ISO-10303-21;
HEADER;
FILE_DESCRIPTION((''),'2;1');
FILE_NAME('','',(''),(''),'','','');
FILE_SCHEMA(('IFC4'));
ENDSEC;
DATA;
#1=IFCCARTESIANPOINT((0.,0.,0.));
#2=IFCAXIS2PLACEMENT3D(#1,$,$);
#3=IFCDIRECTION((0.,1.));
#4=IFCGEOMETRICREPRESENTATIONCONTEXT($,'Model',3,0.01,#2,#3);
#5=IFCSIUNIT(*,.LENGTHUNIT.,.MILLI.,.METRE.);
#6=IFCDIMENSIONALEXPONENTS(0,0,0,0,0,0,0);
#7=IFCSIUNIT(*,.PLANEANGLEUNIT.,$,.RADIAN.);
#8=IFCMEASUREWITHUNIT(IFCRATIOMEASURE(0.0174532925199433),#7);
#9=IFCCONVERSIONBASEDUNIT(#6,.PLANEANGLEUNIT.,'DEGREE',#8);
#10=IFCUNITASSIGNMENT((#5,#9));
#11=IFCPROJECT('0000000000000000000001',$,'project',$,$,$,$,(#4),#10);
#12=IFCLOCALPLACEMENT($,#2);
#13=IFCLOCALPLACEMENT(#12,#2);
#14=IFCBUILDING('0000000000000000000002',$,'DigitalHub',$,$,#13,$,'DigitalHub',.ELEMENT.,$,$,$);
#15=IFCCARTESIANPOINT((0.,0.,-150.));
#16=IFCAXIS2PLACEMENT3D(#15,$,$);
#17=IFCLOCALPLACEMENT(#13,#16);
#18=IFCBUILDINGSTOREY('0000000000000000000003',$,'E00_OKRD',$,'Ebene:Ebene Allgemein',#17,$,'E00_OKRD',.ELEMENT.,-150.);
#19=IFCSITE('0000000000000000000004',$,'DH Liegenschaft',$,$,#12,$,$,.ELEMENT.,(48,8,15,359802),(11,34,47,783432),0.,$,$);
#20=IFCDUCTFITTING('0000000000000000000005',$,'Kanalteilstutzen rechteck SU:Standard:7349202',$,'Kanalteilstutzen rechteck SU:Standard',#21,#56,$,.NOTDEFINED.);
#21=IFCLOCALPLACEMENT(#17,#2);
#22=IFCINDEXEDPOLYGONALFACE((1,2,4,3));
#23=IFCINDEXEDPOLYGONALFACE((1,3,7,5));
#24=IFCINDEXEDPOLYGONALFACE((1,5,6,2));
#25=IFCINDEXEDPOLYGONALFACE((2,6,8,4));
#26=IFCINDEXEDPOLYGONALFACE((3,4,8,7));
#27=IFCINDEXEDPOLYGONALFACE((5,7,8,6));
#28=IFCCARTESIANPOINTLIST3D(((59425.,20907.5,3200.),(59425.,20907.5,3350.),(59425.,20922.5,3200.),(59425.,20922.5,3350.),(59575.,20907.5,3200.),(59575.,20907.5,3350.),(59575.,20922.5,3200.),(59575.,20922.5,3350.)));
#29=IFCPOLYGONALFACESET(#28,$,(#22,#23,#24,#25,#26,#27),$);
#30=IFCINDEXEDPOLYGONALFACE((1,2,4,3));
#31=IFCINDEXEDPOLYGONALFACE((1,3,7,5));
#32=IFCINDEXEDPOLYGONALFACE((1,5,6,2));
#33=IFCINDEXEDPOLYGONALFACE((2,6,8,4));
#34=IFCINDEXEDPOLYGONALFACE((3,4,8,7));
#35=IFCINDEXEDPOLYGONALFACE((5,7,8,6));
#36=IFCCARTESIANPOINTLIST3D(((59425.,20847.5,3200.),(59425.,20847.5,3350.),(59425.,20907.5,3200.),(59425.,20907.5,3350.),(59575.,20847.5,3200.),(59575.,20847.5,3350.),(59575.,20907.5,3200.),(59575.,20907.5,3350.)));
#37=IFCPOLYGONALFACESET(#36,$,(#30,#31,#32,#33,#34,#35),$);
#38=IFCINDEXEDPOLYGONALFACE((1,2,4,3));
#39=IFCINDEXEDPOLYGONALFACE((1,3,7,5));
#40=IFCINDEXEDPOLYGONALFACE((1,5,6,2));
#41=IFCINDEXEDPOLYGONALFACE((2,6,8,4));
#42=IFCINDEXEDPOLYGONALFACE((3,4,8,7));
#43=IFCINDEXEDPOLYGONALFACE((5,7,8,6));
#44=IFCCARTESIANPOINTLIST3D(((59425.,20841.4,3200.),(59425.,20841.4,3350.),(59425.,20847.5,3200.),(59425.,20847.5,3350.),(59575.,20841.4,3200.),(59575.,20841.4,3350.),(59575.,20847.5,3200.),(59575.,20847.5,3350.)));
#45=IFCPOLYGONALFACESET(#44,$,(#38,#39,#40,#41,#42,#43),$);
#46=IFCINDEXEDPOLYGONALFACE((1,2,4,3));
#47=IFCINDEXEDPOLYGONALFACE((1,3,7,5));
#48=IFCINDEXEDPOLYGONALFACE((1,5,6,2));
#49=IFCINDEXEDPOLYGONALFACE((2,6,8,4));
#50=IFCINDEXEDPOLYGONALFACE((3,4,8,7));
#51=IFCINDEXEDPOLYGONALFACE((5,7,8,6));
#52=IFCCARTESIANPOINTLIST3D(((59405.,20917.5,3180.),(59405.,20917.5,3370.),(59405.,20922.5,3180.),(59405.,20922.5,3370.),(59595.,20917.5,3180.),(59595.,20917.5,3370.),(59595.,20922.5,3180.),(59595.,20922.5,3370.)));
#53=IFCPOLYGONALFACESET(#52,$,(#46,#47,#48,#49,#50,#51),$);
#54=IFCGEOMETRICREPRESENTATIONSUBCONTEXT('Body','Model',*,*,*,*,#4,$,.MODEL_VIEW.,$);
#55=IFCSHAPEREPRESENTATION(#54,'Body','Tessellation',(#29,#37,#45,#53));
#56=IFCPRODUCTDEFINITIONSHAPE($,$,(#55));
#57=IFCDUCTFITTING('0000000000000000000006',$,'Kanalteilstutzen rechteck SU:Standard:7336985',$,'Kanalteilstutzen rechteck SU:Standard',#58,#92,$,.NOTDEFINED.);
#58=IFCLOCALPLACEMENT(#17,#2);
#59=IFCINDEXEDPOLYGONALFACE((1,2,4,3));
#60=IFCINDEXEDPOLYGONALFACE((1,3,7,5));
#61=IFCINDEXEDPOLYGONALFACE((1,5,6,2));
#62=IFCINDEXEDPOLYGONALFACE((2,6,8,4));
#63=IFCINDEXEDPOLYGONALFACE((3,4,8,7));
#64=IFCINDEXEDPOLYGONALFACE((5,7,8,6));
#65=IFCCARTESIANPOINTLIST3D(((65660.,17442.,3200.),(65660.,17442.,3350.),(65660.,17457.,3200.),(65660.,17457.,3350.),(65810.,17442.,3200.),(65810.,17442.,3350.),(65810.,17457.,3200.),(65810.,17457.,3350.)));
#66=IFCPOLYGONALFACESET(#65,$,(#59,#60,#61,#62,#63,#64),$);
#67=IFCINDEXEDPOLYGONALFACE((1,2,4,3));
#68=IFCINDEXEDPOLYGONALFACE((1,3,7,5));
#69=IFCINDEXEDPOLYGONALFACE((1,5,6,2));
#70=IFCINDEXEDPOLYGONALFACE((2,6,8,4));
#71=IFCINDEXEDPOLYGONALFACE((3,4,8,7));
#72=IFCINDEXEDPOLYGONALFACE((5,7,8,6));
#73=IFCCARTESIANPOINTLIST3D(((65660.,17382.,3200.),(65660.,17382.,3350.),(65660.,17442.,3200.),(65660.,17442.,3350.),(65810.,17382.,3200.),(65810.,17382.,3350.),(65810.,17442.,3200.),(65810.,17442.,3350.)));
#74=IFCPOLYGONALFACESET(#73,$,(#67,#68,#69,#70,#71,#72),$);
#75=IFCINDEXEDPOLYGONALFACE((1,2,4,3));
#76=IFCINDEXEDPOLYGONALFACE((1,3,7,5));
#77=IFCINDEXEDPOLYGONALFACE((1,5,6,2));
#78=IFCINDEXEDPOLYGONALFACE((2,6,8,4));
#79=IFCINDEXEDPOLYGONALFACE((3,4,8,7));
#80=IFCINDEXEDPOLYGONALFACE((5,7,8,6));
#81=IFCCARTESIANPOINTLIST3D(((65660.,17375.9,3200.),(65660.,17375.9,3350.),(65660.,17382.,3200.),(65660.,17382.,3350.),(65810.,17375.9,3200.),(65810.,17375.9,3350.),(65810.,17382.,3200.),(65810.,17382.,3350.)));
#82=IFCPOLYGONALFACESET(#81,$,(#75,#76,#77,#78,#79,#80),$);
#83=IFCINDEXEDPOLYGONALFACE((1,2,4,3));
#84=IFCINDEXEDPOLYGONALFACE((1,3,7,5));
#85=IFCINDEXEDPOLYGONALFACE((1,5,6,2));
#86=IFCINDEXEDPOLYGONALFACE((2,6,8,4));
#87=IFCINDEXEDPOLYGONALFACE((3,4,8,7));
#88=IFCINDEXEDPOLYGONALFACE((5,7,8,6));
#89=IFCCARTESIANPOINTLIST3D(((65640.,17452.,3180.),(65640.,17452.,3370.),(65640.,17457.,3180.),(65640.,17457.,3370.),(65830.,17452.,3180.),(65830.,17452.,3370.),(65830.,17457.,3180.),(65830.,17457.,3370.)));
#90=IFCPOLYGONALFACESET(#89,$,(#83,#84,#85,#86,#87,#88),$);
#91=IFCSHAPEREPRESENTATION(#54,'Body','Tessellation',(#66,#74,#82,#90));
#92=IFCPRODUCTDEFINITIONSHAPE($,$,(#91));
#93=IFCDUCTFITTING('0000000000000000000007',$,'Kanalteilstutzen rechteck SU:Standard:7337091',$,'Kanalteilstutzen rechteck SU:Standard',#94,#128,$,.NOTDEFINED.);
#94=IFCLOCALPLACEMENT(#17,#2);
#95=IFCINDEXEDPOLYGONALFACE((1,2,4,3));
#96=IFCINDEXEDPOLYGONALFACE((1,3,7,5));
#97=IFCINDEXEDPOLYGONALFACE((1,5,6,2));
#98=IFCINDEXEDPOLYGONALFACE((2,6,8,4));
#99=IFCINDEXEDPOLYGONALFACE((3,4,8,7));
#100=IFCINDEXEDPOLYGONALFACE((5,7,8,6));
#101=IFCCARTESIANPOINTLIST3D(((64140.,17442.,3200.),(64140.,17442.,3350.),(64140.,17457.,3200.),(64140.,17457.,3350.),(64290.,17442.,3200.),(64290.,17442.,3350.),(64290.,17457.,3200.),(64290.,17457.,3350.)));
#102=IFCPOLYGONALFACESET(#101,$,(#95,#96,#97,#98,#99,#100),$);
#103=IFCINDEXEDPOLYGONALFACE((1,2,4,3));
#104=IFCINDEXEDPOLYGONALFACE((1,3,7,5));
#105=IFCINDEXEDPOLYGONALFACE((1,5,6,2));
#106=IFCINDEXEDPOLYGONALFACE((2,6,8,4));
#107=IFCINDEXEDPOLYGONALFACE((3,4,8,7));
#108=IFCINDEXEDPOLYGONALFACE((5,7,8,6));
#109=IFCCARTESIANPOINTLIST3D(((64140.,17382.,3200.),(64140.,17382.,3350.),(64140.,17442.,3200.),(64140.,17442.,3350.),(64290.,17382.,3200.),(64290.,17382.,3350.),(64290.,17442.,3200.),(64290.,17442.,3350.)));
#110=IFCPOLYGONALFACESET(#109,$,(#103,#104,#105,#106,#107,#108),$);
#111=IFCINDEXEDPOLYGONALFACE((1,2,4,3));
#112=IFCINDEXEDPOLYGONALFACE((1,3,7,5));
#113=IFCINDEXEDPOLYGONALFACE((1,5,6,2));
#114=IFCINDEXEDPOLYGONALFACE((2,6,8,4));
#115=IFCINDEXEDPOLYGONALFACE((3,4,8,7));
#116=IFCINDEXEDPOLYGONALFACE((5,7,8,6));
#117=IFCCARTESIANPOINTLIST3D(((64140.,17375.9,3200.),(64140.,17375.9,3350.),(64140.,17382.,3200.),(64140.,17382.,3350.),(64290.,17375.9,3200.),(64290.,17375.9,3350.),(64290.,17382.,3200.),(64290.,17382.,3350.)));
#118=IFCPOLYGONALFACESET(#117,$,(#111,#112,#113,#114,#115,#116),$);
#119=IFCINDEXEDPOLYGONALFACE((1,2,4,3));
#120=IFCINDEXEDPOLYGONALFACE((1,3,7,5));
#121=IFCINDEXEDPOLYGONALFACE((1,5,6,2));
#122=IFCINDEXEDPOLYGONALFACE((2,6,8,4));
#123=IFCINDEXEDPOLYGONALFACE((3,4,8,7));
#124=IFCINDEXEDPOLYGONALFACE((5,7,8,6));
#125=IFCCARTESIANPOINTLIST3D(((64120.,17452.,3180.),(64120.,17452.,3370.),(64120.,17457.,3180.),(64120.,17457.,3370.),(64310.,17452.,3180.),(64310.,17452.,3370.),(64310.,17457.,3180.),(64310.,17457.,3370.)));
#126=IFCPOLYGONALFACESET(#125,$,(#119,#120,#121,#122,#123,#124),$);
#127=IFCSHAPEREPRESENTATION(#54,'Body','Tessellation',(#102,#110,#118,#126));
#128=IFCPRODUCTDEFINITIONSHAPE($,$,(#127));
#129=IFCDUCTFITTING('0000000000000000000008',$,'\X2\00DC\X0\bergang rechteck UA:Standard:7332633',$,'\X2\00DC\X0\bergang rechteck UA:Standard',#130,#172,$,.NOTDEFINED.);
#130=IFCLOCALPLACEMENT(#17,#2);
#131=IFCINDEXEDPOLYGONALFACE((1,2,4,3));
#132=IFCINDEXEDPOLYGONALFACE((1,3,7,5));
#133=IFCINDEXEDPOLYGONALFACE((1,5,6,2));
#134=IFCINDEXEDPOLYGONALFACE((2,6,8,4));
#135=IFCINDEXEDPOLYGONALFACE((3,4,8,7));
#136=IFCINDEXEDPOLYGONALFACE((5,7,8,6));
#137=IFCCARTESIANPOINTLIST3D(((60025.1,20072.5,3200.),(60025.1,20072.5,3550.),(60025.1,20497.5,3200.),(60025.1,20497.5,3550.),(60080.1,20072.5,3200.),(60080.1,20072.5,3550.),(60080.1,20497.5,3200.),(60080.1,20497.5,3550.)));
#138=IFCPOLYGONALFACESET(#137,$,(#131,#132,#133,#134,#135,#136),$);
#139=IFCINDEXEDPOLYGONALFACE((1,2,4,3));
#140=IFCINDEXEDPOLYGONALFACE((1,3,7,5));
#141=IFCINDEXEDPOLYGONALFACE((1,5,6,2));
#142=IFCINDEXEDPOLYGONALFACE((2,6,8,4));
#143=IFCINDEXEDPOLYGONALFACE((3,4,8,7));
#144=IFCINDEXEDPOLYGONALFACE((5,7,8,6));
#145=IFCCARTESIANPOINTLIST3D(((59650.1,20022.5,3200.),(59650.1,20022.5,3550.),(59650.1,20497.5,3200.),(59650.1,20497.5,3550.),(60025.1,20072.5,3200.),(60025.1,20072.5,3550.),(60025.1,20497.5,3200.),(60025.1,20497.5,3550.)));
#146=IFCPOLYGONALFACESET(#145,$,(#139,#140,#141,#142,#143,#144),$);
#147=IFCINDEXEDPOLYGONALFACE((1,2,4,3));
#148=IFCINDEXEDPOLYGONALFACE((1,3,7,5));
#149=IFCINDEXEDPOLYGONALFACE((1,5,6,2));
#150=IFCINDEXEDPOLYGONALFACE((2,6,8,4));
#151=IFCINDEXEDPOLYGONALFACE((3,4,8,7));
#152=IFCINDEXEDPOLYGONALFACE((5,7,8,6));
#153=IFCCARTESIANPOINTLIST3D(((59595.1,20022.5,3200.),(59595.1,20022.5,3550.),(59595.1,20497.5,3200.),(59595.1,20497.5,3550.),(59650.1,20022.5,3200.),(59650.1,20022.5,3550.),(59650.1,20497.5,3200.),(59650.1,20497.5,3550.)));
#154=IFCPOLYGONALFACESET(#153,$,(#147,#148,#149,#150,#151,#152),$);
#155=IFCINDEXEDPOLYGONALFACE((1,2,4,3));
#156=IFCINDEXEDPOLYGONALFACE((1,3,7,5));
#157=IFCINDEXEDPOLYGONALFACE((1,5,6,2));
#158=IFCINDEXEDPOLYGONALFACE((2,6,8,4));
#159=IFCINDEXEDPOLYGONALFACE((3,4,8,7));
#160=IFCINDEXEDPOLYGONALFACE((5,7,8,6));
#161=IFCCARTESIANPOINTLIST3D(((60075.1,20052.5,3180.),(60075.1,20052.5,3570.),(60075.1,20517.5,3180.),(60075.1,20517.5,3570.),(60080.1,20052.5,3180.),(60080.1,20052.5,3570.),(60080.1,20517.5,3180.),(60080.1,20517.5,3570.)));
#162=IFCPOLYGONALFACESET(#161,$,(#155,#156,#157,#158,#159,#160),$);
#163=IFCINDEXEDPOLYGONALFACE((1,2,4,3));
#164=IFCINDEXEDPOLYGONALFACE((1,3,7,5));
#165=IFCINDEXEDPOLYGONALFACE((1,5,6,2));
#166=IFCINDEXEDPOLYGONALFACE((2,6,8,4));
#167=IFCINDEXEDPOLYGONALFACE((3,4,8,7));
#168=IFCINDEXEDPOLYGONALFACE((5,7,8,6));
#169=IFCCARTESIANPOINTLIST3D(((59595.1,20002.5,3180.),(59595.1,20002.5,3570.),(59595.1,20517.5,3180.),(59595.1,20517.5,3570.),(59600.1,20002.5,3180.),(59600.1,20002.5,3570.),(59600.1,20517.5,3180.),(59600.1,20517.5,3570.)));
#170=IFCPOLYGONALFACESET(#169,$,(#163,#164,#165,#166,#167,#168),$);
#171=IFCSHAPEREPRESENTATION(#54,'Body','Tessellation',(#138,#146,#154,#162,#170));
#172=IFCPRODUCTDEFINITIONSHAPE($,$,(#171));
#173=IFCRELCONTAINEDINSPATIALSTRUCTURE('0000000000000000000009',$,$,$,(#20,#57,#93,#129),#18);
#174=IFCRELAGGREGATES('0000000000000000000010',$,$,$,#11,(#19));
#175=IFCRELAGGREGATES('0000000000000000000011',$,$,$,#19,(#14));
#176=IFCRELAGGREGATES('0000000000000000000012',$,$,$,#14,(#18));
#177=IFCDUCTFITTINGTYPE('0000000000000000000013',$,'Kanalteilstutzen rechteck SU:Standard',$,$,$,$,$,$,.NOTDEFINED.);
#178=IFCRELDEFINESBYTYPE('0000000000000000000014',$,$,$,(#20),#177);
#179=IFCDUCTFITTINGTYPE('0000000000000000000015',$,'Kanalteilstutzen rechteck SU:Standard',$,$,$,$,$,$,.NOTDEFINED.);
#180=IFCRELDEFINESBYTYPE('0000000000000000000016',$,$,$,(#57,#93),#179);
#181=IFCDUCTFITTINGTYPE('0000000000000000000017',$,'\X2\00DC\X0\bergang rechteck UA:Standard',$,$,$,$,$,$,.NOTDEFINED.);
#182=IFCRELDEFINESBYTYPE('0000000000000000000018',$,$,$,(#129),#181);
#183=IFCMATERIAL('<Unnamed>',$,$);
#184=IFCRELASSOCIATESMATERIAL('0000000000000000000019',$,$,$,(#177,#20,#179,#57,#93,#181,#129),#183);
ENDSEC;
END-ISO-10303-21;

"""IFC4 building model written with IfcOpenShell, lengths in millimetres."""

from ifc_helpers import new_model, entity, si_unit, converted_unit, direction, frame, origin, place, context, subcontext, project, spatial, indexed_curve, outline, extrude, source, transform, mapped, material, type_object, type_shapes, element, save


model = new_model("IFC4")

# Units and contexts
model_context = context("Model", 3, precision=0.01, world=origin(), true_north=direction((0.0, 1.0)))
body_context = subcontext(model_context, "Body", "Model", "MODEL_VIEW")
ifc_project = project(units=[si_unit("LENGTHUNIT", "METRE", prefix="MILLI"), converted_unit("PLANEANGLEUNIT", "DEGREE", entity("IfcRatioMeasure", 0.0174532925199433), si_unit("PLANEANGLEUNIT", "RADIAN"), dimensions=[0, 0, 0, 0, 0, 0, 0])], contexts=[model_context])

# Site, building, storey
site_placement = place(None, origin())
site = spatial("IfcSite", under=ifc_project, at=site_placement, Name="DH Liegenschaft", CompositionType="ELEMENT", RefLatitude=(48, 8, 15, 359802), RefLongitude=(11, 34, 47, 783432), RefElevation=0.0)
building_placement = place(site_placement, origin())
building = spatial("IfcBuilding", under=site, at=building_placement, Name="DigitalHub", LongName="DigitalHub", CompositionType="ELEMENT")
storey_placement = place(building_placement, frame((0.0, 0.0, -150.0)))
storey = spatial("IfcBuildingStorey", under=building, at=storey_placement, Name="E00_OKRD", ObjectType="Ebene:Ebene Allgemein", LongName="E00_OKRD", CompositionType="ELEMENT", Elevation=-150.0)

# Shared definitions
ifc_material_1 = material(Name="<Unnamed>")

# Duct fittings
duct_fitting_type_1 = type_object("IfcDuctFittingType", Name="Kanalteilstutzen rechteck SU:Standard", PredefinedType="NOTDEFINED", material=ifc_material_1)
shared_shape_1 = source(origin(), body_context, "Body", "SweptSolid", [
    extrude(outline(indexed_curve([(-75.0, -7.5), (75.0, -7.5), (75.0, 7.5), (-75.0, 7.5), (-75.0, -7.5)], self_intersect=False)), frame((67.5, 0.0, -75.0), z_axis=(0.0, 0.0, 1.0), x_axis=(0.0, -1.0, 0.0)), (0.0, 0.0, 1.0), 150.0),
    extrude(outline(indexed_curve([(-75.0, -30.0), (75.0, -30.0), (75.0, 30.0), (-75.0, 30.0), (-75.0, -30.0)], self_intersect=False)), frame((30.0, 0.0, -75.0), z_axis=(0.0, 0.0, 1.0), x_axis=(0.0, -1.0, 0.0)), (0.0, 0.0, 1.0), 150.0),
    extrude(outline(indexed_curve([(-75.0, -3.0), (75.0, -3.0), (75.0, 3.0), (-75.0, 3.0), (-75.0, -3.0)], self_intersect=False)), frame((-3.0, 0.0, -75.0), z_axis=(0.0, 0.0, 1.0), x_axis=(0.0, -1.0, 0.0)), (0.0, 0.0, 1.0), 150.0),
    extrude(outline(indexed_curve([(-95.0, -2.5), (95.0, -2.5), (95.0, 2.5), (-95.0, 2.5), (-95.0, -2.5)], self_intersect=False)), frame((72.5, 0.0, -95.0), z_axis=(0.0, 0.0, 1.0), x_axis=(0.0, -1.0, 0.0)), (0.0, 0.0, 1.0), 190.0),
])
type_shapes(duct_fitting_type_1, [shared_shape_1])
duct_fitting_1_placement = place(storey_placement, frame((59500.0, 20847.5, 3275.0), z_axis=(0.0, 0.0, -1.0), x_axis=(0.0, 1.0, 0.0)))
element("IfcDuctFitting", 1, at=duct_fitting_1_placement, inside=storey, type_object=duct_fitting_type_1, material=ifc_material_1, Name="Kanalteilstutzen rechteck SU:Standard:7349202", ObjectType="Kanalteilstutzen rechteck SU:Standard", PredefinedType="NOTDEFINED", context=body_context, shape_type="MappedRepresentation", body=[
    mapped(shared_shape_1, transform((0.0, 0.0, 0.0), scale=1.0)),
])
duct_fitting_type_2 = type_object("IfcDuctFittingType", Name="Kanalteilstutzen rechteck SU:Standard", PredefinedType="NOTDEFINED", material=ifc_material_1)
shared_shape_2 = source(origin(), body_context, "Body", "SweptSolid", [
    extrude(outline(indexed_curve([(-7.5, -75.0), (7.5, -75.0), (7.5, 75.0), (-7.5, 75.0), (-7.5, -75.0)], self_intersect=False)), frame((67.5, 0.0, -75.0)), (0.0, 0.0, 1.0), 150.0),
    extrude(outline(indexed_curve([(-30.0, -75.0), (30.0, -75.0), (30.0, 75.0), (-30.0, 75.0), (-30.0, -75.0)], self_intersect=False)), frame((30.0, 0.0, -75.0)), (0.0, 0.0, 1.0), 150.0),
    extrude(outline(indexed_curve([(-3.0, -75.0), (3.0, -75.0), (3.0, 75.0), (-3.0, 75.0), (-3.0, -75.0)], self_intersect=False)), frame((-3.0, 0.0, -75.0)), (0.0, 0.0, 1.0), 150.0),
    extrude(outline(indexed_curve([(-2.5, -95.0), (2.5, -95.0), (2.5, 95.0), (-2.5, 95.0), (-2.5, -95.0)], self_intersect=False)), frame((72.5, 0.0, -95.0)), (0.0, 0.0, 1.0), 190.0),
])
type_shapes(duct_fitting_type_2, [shared_shape_2])
for number, where, z_axis, x_axis, name in (
    (2, (65735.0, 17382.0, 3275.0), (0.0, 0.0, -1.0), (0.0, 1.0, 0.0), "Kanalteilstutzen rechteck SU:Standard:7336985"),
    (3, (64215.0, 17382.0, 3275.0), (0.0, 0.0, -1.0), (0.0, 1.0, 0.0), "Kanalteilstutzen rechteck SU:Standard:7337091"),
):
    element("IfcDuctFitting", number, at=place(storey_placement, frame(where, z_axis=z_axis, x_axis=x_axis)), inside=storey, type_object=duct_fitting_type_2, material=ifc_material_1, Name=name, ObjectType="Kanalteilstutzen rechteck SU:Standard", PredefinedType="NOTDEFINED", context=body_context, shape_type="MappedRepresentation", body=[
        mapped(shared_shape_2, transform((0.0, 0.0, 0.0), scale=1.0)),
    ])
duct_fitting_type_3 = type_object("IfcDuctFittingType", Name="Übergang rechteck UA:Standard", PredefinedType="NOTDEFINED", material=ifc_material_1)
shared_shape_3 = source(origin(), body_context, "Body", "SweptSolid", [
    extrude(outline(indexed_curve([(-27.5, -212.5), (27.5, -212.5), (27.5, 212.5), (-27.5, 212.5), (-27.5, -212.5)], self_intersect=False)), frame((457.5, 25.0, -175.0)), (0.0, 0.0, 1.0), 350.0),
    extrude(outline(indexed_curve([(-218.9, -223.0), (159.4, -223.0), (215.6, 198.2), (-156.1, 247.8), (-218.9, -223.0)], self_intersect=False)), frame((242.5, 12.5, -175.0), z_axis=(0.0, 0.0, 1.0), x_axis=(0.991228, 0.132164, 0.0)), (0.0, 0.0, 1.0), 350.0),
    extrude(outline(indexed_curve([(-27.5, -237.5), (27.5, -237.5), (27.5, 237.5), (-27.5, 237.5), (-27.5, -237.5)], self_intersect=False)), frame((27.5, 0.0, -175.0)), (0.0, 0.0, 1.0), 350.0),
    extrude(outline(indexed_curve([(-2.5, -232.5), (2.5, -232.5), (2.5, 232.5), (-2.5, 232.5), (-2.5, -232.5)], self_intersect=False)), frame((482.5, 25.0, -195.0)), (0.0, 0.0, 1.0), 390.0),
    extrude(outline(indexed_curve([(-2.5, -257.5), (2.5, -257.5), (2.5, 257.5), (-2.5, 257.5), (-2.5, -257.5)], self_intersect=False)), frame((2.5, 0.0, -195.0)), (0.0, 0.0, 1.0), 390.0),
])
type_shapes(duct_fitting_type_3, [shared_shape_3])
duct_fitting_2_placement = place(storey_placement, frame((59595.1, 20260.0, 3375.0)))
element("IfcDuctFitting", 4, at=duct_fitting_2_placement, inside=storey, type_object=duct_fitting_type_3, material=ifc_material_1, Name="Übergang rechteck UA:Standard:7332633", ObjectType="Übergang rechteck UA:Standard", PredefinedType="NOTDEFINED", context=body_context, shape_type="MappedRepresentation", body=[
    mapped(shared_shape_3, transform((0.0, 0.0, 0.0), scale=1.0)),
])

save(model, "model.ifc")
